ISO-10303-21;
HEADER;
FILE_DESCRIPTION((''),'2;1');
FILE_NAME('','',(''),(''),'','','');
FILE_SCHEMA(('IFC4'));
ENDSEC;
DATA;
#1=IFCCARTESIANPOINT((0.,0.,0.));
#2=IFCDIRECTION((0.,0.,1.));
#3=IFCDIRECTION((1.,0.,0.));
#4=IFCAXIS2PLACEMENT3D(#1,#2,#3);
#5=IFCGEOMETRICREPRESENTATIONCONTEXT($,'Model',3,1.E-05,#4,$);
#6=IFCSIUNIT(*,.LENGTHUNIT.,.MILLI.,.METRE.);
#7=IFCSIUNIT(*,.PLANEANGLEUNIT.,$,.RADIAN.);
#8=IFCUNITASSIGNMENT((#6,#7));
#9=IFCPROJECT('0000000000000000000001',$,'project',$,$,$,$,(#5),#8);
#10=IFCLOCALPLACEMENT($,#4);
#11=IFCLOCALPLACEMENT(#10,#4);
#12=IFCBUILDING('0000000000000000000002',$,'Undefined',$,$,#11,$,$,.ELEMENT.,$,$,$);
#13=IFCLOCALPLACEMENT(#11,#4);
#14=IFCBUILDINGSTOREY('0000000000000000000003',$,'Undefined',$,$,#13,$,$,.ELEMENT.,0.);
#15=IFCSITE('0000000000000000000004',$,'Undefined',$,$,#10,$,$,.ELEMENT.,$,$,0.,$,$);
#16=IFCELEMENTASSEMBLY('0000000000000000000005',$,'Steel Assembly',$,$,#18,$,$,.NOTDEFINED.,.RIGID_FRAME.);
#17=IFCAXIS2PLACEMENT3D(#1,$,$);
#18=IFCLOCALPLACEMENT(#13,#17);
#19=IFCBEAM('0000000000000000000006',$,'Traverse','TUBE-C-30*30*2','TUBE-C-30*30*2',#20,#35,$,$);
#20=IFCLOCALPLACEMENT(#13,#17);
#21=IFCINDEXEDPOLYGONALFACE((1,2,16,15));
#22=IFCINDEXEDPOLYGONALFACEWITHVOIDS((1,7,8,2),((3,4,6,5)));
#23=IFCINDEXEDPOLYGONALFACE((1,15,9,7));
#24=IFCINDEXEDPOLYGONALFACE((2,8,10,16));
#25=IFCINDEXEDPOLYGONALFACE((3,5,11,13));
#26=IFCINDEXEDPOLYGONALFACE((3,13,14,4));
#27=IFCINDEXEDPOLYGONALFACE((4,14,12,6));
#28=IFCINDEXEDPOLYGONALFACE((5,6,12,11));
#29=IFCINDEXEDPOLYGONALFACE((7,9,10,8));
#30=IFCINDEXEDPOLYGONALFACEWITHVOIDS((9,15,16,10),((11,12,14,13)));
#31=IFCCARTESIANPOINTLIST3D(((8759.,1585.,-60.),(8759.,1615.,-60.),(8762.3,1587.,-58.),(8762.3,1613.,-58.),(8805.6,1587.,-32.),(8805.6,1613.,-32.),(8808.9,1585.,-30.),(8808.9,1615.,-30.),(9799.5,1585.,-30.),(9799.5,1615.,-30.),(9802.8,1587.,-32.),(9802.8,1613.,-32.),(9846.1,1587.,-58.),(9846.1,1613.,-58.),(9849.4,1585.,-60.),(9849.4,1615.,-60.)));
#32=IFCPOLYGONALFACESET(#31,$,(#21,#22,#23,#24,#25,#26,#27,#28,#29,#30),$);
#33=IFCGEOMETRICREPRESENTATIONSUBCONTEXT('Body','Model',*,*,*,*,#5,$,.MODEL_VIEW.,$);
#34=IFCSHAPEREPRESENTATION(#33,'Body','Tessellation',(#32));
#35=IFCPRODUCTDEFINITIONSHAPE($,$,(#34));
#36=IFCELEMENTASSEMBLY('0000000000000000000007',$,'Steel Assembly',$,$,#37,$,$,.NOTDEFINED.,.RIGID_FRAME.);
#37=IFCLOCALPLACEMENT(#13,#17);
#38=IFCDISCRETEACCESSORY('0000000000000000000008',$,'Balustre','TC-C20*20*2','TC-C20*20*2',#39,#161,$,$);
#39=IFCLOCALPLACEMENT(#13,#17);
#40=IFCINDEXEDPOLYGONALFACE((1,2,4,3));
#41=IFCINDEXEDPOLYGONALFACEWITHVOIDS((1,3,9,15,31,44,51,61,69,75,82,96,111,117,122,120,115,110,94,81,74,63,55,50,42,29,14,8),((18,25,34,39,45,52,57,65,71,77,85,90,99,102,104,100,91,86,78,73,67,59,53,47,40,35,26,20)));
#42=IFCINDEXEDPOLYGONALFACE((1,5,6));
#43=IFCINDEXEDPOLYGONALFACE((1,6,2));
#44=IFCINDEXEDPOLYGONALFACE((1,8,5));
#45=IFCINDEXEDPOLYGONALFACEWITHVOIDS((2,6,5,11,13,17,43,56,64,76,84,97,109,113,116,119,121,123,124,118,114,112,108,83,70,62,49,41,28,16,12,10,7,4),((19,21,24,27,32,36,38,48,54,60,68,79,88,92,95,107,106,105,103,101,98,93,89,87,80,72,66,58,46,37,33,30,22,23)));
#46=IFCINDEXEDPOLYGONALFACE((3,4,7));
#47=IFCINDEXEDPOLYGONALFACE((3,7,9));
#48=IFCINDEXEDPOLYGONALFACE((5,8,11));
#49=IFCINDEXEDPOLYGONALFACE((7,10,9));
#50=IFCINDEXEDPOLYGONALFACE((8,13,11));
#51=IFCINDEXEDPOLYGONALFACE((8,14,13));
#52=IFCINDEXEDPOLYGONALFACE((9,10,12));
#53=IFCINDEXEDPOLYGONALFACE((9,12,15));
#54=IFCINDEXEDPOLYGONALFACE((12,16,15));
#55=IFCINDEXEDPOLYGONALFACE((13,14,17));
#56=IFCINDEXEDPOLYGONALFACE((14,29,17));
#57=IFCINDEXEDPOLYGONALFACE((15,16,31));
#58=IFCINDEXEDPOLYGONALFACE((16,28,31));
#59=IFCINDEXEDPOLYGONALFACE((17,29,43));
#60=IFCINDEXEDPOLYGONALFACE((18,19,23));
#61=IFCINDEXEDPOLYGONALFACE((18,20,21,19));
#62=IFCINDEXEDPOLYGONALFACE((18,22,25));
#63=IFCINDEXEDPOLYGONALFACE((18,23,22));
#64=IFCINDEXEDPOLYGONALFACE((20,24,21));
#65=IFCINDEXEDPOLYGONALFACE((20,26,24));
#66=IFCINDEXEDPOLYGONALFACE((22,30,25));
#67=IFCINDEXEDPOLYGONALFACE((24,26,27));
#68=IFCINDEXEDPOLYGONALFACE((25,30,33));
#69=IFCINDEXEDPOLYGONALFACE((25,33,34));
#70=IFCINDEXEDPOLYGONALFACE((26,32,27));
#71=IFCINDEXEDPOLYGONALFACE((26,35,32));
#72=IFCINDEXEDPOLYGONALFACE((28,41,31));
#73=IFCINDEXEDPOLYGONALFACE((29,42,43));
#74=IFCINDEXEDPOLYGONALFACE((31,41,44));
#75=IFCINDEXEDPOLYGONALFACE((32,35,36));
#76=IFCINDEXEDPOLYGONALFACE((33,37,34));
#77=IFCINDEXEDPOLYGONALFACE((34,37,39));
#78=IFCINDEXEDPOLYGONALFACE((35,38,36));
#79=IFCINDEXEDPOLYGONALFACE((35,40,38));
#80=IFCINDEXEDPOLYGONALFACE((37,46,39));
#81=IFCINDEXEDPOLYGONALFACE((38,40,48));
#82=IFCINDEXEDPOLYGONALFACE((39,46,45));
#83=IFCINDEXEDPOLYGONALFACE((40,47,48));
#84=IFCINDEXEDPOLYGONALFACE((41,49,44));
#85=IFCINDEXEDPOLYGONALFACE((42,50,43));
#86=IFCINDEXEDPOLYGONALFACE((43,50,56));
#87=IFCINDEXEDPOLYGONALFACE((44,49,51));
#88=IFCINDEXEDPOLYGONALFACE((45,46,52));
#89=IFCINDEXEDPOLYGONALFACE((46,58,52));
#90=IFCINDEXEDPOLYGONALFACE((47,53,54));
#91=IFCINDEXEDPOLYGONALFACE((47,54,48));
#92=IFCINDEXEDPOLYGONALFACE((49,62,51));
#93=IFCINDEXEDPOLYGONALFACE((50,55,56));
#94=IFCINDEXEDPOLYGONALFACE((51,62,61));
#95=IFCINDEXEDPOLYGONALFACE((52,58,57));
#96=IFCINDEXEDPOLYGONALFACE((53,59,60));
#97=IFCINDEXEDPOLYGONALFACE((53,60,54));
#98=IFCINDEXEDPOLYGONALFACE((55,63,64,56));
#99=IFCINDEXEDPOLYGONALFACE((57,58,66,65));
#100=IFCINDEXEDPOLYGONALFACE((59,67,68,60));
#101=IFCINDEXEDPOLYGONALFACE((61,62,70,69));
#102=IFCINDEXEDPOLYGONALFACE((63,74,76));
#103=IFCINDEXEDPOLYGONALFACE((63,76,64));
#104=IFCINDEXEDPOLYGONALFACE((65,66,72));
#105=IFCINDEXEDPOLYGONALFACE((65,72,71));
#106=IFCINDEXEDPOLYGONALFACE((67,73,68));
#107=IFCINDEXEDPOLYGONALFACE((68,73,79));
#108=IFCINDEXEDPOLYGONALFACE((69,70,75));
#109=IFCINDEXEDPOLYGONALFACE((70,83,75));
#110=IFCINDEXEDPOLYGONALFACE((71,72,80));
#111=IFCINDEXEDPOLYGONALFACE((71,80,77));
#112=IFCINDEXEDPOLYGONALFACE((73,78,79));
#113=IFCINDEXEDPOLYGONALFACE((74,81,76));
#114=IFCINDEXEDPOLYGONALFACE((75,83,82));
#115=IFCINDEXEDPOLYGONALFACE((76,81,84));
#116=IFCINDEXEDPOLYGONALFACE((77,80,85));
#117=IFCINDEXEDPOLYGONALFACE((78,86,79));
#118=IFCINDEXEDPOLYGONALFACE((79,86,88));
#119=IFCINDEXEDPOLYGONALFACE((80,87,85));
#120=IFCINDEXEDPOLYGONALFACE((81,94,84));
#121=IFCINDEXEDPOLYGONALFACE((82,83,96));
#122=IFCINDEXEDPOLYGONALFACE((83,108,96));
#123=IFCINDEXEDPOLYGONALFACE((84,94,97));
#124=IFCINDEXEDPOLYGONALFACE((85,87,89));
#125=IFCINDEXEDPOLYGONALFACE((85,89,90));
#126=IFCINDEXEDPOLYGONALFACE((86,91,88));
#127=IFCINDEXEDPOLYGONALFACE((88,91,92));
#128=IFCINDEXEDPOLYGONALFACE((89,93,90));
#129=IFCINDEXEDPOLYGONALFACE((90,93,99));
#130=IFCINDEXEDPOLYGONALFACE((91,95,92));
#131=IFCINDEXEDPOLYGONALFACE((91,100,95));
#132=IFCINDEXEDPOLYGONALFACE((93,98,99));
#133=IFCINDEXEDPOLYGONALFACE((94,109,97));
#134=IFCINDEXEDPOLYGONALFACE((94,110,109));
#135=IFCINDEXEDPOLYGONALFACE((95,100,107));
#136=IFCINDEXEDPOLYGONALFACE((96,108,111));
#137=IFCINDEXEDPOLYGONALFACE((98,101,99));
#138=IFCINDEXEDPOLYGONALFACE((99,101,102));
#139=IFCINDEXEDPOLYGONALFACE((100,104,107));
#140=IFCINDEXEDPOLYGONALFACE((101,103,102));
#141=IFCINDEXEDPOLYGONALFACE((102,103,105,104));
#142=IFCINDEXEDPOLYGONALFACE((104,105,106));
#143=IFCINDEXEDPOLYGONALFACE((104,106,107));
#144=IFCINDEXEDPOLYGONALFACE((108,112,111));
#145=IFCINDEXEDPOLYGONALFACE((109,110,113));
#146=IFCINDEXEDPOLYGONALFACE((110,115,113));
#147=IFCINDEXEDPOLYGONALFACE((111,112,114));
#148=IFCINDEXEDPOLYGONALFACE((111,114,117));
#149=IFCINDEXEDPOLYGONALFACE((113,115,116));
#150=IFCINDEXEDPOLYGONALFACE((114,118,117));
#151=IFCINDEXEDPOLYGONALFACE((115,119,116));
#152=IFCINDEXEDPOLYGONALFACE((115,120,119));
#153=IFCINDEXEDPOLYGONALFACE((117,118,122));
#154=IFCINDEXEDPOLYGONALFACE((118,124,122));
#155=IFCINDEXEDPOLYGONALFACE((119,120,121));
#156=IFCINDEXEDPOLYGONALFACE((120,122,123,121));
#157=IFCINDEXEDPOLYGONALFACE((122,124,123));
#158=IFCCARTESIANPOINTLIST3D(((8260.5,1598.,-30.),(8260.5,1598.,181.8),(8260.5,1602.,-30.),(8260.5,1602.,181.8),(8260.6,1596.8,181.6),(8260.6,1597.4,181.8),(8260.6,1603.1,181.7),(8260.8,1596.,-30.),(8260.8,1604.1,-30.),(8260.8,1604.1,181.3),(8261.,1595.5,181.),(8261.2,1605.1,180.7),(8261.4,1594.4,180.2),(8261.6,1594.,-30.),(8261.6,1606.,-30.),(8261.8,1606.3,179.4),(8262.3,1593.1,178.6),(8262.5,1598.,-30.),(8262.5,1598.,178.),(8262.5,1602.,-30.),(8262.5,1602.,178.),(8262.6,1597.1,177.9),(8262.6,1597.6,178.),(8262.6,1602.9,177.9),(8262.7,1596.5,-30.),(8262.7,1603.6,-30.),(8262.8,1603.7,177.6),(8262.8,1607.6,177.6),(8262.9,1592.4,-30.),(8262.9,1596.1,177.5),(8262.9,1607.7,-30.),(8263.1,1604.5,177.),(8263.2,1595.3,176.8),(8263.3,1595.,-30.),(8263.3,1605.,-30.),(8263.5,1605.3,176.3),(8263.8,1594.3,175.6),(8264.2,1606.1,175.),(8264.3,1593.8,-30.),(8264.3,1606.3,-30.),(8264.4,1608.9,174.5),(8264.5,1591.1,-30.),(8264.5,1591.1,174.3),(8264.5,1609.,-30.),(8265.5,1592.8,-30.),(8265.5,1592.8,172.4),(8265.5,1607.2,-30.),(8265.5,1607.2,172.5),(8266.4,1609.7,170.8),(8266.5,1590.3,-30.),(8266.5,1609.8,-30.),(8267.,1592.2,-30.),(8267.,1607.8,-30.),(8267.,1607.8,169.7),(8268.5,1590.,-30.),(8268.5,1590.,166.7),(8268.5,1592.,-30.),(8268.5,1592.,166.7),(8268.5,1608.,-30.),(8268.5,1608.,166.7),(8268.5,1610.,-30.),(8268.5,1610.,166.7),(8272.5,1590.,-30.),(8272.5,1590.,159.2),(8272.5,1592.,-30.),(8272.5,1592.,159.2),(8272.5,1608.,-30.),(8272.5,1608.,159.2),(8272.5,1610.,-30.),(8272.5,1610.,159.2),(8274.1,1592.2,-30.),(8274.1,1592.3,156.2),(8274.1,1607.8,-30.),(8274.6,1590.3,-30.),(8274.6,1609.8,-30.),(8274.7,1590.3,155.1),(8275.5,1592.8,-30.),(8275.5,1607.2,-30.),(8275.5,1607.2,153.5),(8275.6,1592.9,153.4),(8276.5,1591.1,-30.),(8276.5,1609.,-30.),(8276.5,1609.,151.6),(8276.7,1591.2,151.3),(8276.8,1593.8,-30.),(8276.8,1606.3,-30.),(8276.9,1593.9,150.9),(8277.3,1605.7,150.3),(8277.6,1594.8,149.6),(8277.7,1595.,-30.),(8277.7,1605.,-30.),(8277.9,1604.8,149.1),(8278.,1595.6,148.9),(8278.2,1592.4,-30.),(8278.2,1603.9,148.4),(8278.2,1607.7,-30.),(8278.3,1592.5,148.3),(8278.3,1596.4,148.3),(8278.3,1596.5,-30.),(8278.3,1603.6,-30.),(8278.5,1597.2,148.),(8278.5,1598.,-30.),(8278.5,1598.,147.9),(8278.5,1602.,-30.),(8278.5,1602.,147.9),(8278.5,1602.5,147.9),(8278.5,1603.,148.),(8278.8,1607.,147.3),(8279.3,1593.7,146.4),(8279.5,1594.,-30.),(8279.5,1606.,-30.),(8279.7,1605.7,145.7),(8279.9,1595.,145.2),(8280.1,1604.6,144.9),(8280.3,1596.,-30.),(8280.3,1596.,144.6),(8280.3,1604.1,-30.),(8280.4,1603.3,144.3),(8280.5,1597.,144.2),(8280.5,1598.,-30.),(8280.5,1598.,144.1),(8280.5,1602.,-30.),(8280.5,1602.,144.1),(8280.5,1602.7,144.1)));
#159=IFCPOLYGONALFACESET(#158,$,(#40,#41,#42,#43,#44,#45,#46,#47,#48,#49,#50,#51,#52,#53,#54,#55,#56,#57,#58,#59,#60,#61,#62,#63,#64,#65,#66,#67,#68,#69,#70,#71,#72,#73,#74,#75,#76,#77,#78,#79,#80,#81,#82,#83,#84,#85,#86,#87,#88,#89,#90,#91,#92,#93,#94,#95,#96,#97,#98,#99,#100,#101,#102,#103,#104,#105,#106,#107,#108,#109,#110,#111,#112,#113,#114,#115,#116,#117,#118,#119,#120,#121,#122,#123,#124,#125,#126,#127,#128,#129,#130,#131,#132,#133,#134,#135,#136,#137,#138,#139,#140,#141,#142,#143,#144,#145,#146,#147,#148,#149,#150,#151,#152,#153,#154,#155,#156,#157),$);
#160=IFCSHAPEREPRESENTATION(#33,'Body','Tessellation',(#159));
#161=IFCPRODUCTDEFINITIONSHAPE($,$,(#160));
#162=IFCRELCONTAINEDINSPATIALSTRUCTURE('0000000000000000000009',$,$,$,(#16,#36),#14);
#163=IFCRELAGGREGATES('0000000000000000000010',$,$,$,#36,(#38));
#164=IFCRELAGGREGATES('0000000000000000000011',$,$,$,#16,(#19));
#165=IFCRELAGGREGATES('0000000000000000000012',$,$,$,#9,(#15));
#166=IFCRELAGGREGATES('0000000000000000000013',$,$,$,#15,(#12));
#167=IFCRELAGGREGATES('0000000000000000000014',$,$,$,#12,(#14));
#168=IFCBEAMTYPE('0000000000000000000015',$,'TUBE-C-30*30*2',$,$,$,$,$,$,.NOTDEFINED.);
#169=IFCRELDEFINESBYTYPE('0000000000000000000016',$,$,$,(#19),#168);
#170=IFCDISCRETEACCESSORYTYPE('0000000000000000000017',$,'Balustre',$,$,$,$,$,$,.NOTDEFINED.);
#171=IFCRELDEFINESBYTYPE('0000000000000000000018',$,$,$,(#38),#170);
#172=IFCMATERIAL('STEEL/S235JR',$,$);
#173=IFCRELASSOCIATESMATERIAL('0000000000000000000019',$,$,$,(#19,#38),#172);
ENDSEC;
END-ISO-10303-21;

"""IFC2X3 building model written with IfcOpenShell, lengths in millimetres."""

from ifc_helpers import new_model, si_unit, frame, origin_with_axes, origin_2d_with_axis, place, context, subcontext, project, spatial, hollow_rectangle, extrude, clip, halfspace, material, type_object, element, aggregate, save


model = new_model("IFC2X3")

# Units and contexts
model_context = context("Model", 3, precision=1e-05, world=origin_with_axes())
body_context = subcontext(model_context, "Body", "Model", "MODEL_VIEW")
ifc_project = project(units=[si_unit("LENGTHUNIT", "METRE", prefix="MILLI"), si_unit("PLANEANGLEUNIT", "RADIAN")], contexts=[model_context])

# Site, building, storey
site_placement = place(None, origin_with_axes())
site = spatial("IfcSite", under=ifc_project, at=site_placement, Name="Undefined", CompositionType="ELEMENT", RefElevation=0.0)
building_placement = place(site_placement, origin_with_axes())
building = spatial("IfcBuilding", under=site, at=building_placement, Name="Undefined", CompositionType="ELEMENT")
storey_placement = place(building_placement, origin_with_axes())
storey = spatial("IfcBuildingStorey", under=building, at=storey_placement, Name="Undefined", CompositionType="ELEMENT", Elevation=0.0)

# Element assembly, beam
assembly_1_placement = place(storey_placement, origin_with_axes())
assembly_1 = element("IfcElementAssembly", 1, at=assembly_1_placement, inside=storey, Name="Steel Assembly", AssemblyPlace="NOTDEFINED", PredefinedType="RIGID_FRAME")
ifc_material = material(Name="STEEL/S235JR")
beam_type = type_object("IfcBeamType", Name="TUBE-C-30*30*2", PredefinedType="NOTDEFINED")
beam_placement = place(assembly_1_placement, frame((8733.6, 1600.0, -45.0), z_axis=(0.000011, -1.0, 0.0), x_axis=(1.0, 0.000011, 0.0)))
beam = element("IfcBeam", 2, at=beam_placement, type_object=beam_type, material=ifc_material, Name="Traverse", Description="TUBE-C-30*30*2", ObjectType="TUBE-C-30*30*2", context=body_context, shape_type="Clipping", body=[
    clip(clip(extrude(hollow_rectangle(XDim=30.0, YDim=30.0, WallThickness=2.0, at=origin_2d_with_axis()), frame((1141.2, 0.0, 0.0), z_axis=(-1.0, 0.0, 0.0), x_axis=(0.0, -1.0, 0.0)), (0.0, 0.0, 1.0), 1141.2), halfspace(frame((1065.9, 15.0, 0.0), z_axis=(0.515548, 0.856861, 0.000003), x_axis=(0.000005, 0.0, -1.0)), False)), halfspace(frame((75.3, 15.0, 0.0), z_axis=(0.515548, -0.856861, 0.000003), x_axis=(0.000005, 0.0, -1.0)), True)),
])

# Element assembly, discrete accessory
assembly_2_placement = place(storey_placement, origin_with_axes())
assembly_2 = element("IfcElementAssembly", 3, at=assembly_2_placement, inside=storey, Name="Steel Assembly", AssemblyPlace="NOTDEFINED", PredefinedType="RIGID_FRAME")
discrete_accessory_type_1 = type_object("IfcDiscreteAccessoryType", Name="Balustre")
discrete_accessory_1_placement = place(assembly_2_placement, frame((8270.5, 1600.0, -30.0), z_axis=(0.0, 0.0, 1.0), x_axis=(1.0, 0.0, 0.0)))
discrete_accessory_1 = element("IfcDiscreteAccessory", 4, at=discrete_accessory_1_placement, type_object=discrete_accessory_type_1, material=ifc_material, Name="Balustre", Description="TC-C20*20*2", ObjectType="TC-C20*20*2", context=body_context, shape_type="Clipping", body=[
    clip(extrude(hollow_rectangle(XDim=20.0, YDim=20.0, WallThickness=2.0, InnerFilletRadius=6.0, OuterFilletRadius=8.0, at=origin_2d_with_axis()), frame((0.0, 0.0, 212.0), z_axis=(0.0, 0.0, -1.0), x_axis=(-1.0, -0.000011, 0.0)), (0.0, 0.0, 1.0), 212.0), halfspace(frame((22.6, 0.0, 150.3), z_axis=(-0.883506, -0.000005, -0.46842), x_axis=(-0.000005, 1.0, 0.0)), True)),
])

aggregate(assembly_2, [discrete_accessory_1])
aggregate(assembly_1, [beam])

save(model, "model.ifc")
